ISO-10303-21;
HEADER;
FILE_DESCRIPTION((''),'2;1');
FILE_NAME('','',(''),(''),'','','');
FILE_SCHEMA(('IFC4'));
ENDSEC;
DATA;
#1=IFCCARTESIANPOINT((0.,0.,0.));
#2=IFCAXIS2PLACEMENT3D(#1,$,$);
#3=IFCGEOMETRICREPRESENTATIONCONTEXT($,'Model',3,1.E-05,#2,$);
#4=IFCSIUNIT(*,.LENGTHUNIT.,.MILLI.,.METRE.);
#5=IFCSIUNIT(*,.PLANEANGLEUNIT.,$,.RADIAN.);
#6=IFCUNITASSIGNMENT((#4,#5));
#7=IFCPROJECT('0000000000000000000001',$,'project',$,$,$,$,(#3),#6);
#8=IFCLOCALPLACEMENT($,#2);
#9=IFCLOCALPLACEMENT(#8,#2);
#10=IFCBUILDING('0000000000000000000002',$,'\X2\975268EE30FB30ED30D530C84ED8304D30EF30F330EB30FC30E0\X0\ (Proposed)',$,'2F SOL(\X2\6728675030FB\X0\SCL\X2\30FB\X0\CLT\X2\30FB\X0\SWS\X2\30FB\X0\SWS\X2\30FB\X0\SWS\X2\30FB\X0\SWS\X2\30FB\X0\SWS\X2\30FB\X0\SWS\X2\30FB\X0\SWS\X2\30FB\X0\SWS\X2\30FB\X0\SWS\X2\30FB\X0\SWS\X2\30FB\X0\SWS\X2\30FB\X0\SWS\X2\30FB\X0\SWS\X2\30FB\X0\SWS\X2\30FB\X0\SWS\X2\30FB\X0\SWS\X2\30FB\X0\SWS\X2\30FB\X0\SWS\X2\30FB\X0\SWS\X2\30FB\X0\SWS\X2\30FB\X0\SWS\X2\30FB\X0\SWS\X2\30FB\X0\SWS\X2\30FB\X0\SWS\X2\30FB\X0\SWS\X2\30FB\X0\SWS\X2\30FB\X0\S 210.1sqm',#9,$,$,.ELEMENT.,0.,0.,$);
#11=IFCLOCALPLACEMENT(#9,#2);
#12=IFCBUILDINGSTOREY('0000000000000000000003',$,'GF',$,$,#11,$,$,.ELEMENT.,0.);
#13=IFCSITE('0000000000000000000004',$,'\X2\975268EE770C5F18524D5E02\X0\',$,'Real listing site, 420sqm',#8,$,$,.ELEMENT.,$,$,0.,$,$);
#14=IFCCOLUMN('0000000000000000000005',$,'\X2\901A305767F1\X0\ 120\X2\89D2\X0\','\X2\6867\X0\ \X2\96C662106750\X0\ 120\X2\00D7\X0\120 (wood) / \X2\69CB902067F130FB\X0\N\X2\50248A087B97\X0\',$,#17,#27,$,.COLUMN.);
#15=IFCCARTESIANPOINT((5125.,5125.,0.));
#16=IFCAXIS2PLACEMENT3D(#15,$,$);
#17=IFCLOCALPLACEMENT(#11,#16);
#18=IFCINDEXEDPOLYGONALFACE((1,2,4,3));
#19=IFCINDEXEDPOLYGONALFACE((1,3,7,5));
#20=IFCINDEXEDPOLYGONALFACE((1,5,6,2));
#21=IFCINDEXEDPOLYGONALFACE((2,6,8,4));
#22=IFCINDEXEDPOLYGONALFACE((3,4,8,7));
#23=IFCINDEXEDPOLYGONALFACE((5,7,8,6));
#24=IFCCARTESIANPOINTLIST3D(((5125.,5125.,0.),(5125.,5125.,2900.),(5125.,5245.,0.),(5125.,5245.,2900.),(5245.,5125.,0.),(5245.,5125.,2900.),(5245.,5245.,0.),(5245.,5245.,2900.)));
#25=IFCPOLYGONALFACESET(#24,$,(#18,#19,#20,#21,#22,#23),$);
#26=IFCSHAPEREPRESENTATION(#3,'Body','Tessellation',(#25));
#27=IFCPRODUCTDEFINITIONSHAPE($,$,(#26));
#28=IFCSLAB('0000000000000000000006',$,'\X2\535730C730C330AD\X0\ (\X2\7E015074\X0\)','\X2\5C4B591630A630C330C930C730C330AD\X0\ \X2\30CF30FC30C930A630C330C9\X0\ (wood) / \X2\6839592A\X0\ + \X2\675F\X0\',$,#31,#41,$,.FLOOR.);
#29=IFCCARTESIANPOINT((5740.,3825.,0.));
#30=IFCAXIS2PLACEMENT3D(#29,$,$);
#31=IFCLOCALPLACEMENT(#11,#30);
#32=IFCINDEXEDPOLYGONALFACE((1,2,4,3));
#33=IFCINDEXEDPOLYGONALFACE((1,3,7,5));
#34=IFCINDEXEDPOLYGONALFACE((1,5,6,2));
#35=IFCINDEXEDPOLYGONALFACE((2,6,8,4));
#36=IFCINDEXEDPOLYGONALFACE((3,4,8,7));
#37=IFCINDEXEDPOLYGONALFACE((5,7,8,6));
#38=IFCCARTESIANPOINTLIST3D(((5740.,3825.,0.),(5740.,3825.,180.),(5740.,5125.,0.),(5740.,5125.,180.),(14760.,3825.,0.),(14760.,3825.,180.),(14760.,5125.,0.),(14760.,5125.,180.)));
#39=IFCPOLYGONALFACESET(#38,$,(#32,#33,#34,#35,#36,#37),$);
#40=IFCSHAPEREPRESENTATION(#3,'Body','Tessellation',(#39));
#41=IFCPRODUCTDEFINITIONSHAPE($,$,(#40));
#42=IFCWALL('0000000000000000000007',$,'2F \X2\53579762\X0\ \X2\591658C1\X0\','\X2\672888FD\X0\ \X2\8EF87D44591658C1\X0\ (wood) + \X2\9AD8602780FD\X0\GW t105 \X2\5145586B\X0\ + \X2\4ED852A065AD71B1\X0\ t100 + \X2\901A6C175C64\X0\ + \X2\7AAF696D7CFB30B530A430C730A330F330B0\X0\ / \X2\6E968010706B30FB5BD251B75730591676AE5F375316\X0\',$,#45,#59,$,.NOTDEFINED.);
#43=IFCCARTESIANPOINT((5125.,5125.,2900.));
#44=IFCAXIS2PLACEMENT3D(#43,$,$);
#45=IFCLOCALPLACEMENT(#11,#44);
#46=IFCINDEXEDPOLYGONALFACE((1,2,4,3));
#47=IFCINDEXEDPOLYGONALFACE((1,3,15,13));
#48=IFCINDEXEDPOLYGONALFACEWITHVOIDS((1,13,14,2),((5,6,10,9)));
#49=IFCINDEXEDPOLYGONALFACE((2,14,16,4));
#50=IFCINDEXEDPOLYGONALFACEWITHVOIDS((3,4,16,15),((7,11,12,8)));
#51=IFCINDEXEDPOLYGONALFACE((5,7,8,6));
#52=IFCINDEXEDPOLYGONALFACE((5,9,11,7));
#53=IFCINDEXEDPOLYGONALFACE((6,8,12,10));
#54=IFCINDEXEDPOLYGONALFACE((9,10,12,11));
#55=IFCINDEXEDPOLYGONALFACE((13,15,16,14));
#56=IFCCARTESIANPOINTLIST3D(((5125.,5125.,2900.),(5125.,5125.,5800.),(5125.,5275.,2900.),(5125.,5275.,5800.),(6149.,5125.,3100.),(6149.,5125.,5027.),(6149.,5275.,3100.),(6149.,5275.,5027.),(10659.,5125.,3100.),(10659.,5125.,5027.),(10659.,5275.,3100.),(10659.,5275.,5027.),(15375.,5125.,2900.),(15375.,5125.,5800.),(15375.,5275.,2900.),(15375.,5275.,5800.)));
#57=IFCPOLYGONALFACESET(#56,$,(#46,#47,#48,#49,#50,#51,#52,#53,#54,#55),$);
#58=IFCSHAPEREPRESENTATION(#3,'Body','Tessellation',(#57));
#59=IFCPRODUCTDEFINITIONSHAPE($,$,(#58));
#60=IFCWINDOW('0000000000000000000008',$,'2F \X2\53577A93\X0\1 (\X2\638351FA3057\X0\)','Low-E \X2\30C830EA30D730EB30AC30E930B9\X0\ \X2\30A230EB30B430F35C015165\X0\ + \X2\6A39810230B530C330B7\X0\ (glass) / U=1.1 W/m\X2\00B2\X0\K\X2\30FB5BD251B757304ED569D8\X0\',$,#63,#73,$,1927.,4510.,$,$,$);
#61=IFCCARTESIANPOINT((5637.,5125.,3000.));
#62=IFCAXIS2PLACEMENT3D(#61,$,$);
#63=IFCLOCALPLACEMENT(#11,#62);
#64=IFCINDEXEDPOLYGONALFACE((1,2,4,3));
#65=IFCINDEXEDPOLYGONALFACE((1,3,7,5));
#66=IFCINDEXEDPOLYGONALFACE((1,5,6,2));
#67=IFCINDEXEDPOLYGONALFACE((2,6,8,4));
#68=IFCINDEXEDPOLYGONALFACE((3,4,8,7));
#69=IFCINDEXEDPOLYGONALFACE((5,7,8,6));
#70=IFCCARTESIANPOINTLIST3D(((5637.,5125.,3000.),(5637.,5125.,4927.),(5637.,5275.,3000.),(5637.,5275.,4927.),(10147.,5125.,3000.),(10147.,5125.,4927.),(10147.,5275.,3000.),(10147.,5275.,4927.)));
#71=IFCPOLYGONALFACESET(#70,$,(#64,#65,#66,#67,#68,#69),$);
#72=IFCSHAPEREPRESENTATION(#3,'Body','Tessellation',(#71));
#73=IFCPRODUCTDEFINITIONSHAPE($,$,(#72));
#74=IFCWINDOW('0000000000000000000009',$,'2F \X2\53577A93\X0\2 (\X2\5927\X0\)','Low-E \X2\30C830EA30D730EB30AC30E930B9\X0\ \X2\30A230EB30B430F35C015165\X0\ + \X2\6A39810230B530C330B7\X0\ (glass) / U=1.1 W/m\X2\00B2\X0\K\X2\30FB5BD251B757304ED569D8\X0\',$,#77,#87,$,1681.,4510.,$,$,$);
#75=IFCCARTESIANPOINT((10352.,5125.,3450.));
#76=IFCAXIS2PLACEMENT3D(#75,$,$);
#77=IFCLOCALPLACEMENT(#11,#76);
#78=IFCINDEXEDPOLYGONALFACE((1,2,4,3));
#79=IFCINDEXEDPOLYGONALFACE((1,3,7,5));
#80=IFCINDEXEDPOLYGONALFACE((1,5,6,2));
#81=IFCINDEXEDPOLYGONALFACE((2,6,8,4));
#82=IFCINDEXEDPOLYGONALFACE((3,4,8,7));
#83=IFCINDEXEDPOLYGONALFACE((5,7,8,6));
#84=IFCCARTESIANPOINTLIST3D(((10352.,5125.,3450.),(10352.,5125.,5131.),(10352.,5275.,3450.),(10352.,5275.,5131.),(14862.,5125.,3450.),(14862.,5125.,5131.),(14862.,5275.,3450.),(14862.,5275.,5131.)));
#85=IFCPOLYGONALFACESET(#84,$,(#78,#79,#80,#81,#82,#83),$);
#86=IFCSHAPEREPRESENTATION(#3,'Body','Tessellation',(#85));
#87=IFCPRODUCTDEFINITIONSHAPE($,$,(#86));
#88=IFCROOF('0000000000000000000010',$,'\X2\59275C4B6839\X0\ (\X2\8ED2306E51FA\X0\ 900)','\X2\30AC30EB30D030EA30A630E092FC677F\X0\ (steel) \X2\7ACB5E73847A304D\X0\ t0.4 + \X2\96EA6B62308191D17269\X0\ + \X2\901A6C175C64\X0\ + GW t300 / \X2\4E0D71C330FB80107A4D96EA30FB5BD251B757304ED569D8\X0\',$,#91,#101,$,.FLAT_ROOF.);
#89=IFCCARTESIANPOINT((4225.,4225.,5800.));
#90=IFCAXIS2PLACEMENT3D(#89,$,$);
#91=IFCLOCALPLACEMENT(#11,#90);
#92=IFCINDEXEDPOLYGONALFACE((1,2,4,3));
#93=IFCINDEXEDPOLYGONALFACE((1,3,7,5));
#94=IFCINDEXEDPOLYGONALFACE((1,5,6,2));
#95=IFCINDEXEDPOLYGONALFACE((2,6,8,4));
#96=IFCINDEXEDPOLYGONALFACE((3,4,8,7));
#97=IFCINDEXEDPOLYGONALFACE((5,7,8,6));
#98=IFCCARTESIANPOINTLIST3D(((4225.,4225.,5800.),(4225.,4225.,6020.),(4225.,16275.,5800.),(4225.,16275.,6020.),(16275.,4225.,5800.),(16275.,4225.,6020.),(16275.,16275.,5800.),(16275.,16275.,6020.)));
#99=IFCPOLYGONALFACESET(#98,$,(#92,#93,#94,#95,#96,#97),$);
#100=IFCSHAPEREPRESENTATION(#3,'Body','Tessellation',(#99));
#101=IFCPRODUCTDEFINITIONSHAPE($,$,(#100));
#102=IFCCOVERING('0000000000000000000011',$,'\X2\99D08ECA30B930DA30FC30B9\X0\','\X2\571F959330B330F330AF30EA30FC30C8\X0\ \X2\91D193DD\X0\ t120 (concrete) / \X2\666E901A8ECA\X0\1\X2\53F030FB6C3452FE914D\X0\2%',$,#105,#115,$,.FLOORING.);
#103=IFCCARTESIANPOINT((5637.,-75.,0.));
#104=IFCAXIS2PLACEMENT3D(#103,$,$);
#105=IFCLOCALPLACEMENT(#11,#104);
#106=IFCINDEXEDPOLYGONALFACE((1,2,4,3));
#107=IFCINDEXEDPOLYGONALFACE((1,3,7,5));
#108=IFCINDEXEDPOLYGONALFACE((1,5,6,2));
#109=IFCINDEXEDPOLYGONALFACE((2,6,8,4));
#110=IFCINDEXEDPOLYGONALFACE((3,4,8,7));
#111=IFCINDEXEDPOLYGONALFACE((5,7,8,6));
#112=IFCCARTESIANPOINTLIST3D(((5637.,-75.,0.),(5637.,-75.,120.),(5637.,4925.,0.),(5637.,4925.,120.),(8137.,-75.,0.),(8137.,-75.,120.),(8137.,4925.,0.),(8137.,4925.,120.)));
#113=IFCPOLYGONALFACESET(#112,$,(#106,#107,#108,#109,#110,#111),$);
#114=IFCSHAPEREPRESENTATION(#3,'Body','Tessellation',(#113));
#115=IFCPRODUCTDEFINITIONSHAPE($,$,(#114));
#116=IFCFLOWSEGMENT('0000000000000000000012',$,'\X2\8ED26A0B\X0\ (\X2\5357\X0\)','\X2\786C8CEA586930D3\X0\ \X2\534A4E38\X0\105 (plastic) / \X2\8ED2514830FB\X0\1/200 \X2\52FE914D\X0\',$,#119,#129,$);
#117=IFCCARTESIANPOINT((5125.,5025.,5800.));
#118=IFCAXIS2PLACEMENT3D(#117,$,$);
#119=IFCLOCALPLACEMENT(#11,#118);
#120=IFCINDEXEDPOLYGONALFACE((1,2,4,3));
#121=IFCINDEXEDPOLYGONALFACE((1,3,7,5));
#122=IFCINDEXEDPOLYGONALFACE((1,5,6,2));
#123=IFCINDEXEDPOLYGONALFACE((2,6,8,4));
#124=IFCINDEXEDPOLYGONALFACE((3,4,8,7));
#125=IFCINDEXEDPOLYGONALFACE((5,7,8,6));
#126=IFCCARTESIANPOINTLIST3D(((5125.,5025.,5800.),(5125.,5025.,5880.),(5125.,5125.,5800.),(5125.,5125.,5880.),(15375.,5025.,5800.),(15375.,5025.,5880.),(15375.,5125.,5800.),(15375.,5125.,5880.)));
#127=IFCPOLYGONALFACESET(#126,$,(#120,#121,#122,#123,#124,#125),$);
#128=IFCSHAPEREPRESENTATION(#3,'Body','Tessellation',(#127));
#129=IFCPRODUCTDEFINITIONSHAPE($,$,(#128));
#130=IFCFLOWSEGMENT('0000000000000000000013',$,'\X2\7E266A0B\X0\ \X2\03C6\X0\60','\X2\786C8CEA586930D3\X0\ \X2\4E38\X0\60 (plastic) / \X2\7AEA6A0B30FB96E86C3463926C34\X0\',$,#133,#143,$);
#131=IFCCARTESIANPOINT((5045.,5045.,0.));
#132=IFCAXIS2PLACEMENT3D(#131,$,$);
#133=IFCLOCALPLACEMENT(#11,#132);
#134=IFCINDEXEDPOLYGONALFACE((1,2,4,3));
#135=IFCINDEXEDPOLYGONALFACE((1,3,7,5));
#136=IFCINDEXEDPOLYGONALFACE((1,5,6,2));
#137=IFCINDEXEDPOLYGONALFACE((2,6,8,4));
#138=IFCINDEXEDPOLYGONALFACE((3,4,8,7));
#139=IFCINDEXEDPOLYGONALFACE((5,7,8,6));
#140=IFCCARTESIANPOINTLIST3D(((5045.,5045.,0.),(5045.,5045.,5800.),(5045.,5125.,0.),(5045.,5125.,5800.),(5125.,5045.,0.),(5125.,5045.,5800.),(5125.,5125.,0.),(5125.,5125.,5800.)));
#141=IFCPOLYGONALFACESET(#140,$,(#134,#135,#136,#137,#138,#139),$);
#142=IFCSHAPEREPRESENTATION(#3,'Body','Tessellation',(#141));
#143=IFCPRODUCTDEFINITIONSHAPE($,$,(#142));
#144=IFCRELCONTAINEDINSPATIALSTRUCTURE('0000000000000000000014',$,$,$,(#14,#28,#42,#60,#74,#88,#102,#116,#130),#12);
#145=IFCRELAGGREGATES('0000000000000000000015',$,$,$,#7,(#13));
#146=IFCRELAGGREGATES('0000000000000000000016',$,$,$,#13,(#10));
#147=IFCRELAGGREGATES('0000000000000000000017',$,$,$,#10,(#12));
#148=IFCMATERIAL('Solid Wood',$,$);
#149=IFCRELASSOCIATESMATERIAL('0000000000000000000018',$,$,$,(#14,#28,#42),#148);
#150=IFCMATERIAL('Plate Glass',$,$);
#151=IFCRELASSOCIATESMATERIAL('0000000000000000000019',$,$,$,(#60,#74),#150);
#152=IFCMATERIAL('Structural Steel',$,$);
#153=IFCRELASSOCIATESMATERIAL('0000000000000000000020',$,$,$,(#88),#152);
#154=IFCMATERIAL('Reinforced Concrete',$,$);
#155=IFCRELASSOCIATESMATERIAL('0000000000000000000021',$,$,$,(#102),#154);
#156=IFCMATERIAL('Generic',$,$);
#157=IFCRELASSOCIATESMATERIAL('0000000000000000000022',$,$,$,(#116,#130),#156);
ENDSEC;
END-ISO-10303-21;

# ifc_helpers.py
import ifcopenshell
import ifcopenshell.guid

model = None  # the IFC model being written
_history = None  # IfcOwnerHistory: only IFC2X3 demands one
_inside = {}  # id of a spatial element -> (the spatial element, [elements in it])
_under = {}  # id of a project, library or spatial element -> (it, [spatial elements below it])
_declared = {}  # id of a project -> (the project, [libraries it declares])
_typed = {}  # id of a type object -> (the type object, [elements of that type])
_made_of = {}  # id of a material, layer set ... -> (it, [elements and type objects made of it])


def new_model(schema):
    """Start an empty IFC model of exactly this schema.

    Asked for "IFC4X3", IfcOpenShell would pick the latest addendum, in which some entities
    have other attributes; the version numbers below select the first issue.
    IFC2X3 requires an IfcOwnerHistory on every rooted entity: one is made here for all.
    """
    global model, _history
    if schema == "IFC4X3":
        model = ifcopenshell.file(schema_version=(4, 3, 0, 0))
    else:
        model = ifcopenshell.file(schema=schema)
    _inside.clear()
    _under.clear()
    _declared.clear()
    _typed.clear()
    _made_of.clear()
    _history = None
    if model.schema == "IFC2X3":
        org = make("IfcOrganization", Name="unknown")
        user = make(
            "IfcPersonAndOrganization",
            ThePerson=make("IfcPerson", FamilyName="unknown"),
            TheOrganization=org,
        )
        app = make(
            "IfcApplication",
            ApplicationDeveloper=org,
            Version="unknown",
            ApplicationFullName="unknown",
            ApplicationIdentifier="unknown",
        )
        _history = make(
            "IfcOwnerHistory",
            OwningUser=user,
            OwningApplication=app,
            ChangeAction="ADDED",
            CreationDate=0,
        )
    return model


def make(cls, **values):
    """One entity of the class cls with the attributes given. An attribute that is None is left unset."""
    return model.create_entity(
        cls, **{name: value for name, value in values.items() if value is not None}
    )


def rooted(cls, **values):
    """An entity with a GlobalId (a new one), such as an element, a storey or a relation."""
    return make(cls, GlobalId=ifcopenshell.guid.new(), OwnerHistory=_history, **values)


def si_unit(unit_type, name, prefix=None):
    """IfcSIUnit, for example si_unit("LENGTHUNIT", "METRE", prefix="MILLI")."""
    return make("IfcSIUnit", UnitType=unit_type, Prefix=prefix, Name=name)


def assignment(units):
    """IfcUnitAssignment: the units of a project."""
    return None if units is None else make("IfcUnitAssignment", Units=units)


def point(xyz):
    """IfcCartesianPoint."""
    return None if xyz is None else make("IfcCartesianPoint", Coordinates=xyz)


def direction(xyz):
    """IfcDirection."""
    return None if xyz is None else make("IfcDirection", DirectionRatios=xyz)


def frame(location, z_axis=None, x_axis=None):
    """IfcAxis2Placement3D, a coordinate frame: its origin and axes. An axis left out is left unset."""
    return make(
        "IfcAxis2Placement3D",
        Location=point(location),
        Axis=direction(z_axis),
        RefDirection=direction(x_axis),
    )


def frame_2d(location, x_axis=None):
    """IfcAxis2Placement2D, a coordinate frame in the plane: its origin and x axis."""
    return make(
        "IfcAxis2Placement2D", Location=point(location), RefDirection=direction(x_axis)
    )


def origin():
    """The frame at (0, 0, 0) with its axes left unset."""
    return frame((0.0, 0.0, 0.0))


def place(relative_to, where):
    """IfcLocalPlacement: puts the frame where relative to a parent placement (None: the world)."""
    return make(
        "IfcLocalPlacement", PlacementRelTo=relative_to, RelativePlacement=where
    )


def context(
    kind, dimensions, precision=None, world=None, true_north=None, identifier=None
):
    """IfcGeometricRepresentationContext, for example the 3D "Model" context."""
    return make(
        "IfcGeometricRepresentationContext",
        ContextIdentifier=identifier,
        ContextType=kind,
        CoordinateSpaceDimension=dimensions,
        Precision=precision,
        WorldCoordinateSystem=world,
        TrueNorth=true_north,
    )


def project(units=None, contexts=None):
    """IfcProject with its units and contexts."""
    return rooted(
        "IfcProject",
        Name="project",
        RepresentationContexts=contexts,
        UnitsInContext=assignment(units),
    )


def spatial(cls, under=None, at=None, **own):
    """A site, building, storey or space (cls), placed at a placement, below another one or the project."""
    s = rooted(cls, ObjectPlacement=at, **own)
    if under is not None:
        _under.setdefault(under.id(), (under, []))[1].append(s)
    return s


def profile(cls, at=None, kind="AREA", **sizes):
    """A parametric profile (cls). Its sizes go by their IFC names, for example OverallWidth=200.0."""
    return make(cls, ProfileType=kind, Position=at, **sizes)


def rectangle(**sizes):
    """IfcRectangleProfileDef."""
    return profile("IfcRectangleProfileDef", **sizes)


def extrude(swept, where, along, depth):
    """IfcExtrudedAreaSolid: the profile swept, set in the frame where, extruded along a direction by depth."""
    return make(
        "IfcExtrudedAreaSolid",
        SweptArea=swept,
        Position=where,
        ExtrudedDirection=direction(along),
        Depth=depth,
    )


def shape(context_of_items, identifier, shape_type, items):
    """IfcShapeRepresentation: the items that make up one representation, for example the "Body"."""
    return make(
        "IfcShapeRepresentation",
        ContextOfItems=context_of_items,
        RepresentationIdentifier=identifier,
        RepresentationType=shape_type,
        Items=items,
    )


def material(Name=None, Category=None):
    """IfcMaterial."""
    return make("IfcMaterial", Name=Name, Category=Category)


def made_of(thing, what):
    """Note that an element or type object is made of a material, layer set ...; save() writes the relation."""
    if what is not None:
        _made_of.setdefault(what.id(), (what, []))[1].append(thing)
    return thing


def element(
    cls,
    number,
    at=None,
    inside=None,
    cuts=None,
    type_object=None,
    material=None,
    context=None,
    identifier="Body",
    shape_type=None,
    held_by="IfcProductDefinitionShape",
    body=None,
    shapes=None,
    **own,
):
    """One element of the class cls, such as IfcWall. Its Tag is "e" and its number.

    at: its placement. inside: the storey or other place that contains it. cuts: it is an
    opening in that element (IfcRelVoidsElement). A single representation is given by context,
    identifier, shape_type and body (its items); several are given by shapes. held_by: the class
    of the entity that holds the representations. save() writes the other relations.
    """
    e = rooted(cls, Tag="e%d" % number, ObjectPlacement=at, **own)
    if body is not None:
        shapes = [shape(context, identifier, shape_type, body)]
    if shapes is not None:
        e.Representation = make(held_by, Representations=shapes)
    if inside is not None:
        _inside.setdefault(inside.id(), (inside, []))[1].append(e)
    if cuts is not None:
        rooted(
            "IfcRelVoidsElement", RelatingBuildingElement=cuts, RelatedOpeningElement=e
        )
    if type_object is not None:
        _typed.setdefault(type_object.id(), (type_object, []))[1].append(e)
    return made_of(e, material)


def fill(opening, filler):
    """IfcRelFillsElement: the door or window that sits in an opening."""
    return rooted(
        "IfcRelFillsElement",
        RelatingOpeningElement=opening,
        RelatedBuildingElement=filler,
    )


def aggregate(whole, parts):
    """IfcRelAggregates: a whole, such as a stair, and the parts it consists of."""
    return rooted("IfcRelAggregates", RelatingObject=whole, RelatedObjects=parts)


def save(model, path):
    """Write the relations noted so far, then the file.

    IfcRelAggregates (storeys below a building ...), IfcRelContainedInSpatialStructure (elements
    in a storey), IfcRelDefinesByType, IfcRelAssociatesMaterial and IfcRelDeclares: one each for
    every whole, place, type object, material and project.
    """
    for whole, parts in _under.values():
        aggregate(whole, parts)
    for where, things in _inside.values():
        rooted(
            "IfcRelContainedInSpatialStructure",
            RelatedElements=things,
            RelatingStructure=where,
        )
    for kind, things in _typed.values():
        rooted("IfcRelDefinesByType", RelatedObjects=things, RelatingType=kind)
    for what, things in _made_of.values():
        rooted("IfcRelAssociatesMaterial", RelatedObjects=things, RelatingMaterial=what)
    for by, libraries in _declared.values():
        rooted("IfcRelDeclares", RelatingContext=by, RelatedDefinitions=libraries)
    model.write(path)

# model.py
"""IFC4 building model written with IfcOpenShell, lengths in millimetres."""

from ifc_helpers import new_model, si_unit, frame, frame_2d, origin, place, context, project, spatial, rectangle, extrude, material, element, fill, save


model = new_model("IFC4")

# Units and contexts
model_context = context("Model", 3, precision=1e-05, world=origin())
ifc_project = project(units=[si_unit("LENGTHUNIT", "METRE", prefix="MILLI"), si_unit("PLANEANGLEUNIT", "RADIAN")], contexts=[model_context])

# Site, building, storey
site_placement = place(None, origin())
site = spatial("IfcSite", under=ifc_project, at=site_placement, Name="青森県弘前市", ObjectType="Real listing site, 420sqm", CompositionType="ELEMENT", RefElevation=0.0)
building_placement = place(site_placement, origin())
building = spatial("IfcBuilding", under=site, at=building_placement, Name="青森・ロフト付きワンルーム (Proposed)", ObjectType="2F SOL(木材・SCL・CLT・SWS・SWS・SWS・SWS・SWS・SWS・SWS・SWS・SWS・SWS・SWS・SWS・SWS・SWS・SWS・SWS・SWS・SWS・SWS・SWS・SWS・SWS・SWS・SWS・SWS・SWS・S 210.1sqm", CompositionType="ELEMENT", ElevationOfRefHeight=0.0, ElevationOfTerrain=0.0)
storey_placement = place(building_placement, origin())
storey = spatial("IfcBuildingStorey", under=building, at=storey_placement, Name="GF", CompositionType="ELEMENT", Elevation=0.0)

# Column
ifc_material_1 = material(Name="Solid Wood")
column_placement = place(storey_placement, frame((5125.0, 5125.0, 0.0)))
element("IfcColumn", 1, at=column_placement, inside=storey, material=ifc_material_1, Name="通し柱 120角", Description="桧 集成材 120×120 (wood) / 構造柱・N値計算", PredefinedType="COLUMN", context=model_context, shape_type="SweptSolid", body=[
    extrude(rectangle(XDim=120.0, YDim=120.0, at=frame_2d((60.0, 60.0))), frame((5125.0, 5125.0, 0.0)), (0.0, 0.0, 1.0), 2900.0),
])

# Slab
ifc_material_2 = material(Name="Reinforced Concrete")
slab_1_placement = place(storey_placement, frame((5740.0, 3825.0, 0.0)))
element("IfcSlab", 2, at=slab_1_placement, inside=storey, material=ifc_material_1, Name="南デッキ (縁側)", Description="屋外ウッドデッキ ハードウッド (wood) / 根太 + 束", PredefinedType="FLOOR", context=model_context, shape_type="SweptSolid", body=[
    extrude(rectangle(XDim=9020.0, YDim=1300.0, at=frame_2d((4510.0, 650.0))), frame((5740.0, 3825.0, 0.0)), (0.0, 0.0, 1.0), 180.0),
])

# Shared definitions
ifc_material_3 = material(Name="Plate Glass")

# Wall, openings, windows
wall_1_placement = place(storey_placement, frame((5125.0, 5125.0, 2900.0)))
wall_1 = element("IfcWall", 3, at=wall_1_placement, inside=storey, material=ifc_material_1, Name="2F 南面 外壁", Description="木製 軸組外壁 (wood) + 高性能GW t105 充填 + 付加断熱 t100 + 通気層 + 窯業系サイディング / 準耐火・寒冷地外皮強化", PredefinedType="NOTDEFINED", context=model_context, shape_type="SweptSolid", body=[
    extrude(rectangle(XDim=10250.0, YDim=150.0, at=frame_2d((5125.0, 75.0))), frame((5125.0, 5125.0, 2900.0)), (0.0, 0.0, 1.0), 2900.0),
])
opening_1_placement = place(storey_placement, frame((5637.0, 5125.0, 3000.0)))
opening_1 = element("IfcOpeningElement", 4, at=opening_1_placement, cuts=wall_1, PredefinedType="NOTDEFINED", context=model_context, shape_type="SweptSolid", body=[
    extrude(rectangle(XDim=4510.0, YDim=150.0, at=frame_2d((2255.0, 75.0))), frame((5637.0, 5125.0, 3000.0)), (0.0, 0.0, 1.0), 1927.0),
])
opening_2_placement = place(storey_placement, frame((10352.0, 5125.0, 3450.0)))
opening_2 = element("IfcOpeningElement", 5, at=opening_2_placement, cuts=wall_1, PredefinedType="NOTDEFINED", context=model_context, shape_type="SweptSolid", body=[
    extrude(rectangle(XDim=4510.0, YDim=150.0, at=frame_2d((2255.0, 75.0))), frame((10352.0, 5125.0, 3450.0)), (0.0, 0.0, 1.0), 1681.0),
])
window_1_placement = place(storey_placement, frame((5637.0, 5125.0, 3000.0)))
window_1 = element("IfcWindow", 6, at=window_1_placement, inside=storey, material=ifc_material_3, Name="2F 南窓1 (掃出し)", Description="Low-E トリプルガラス アルゴン封入 + 樹脂サッシ (glass) / U=1.1 W/m²K・寒冷地仕様", OverallHeight=1927.0, OverallWidth=4510.0, context=model_context, shape_type="SweptSolid", body=[
    extrude(rectangle(XDim=4510.0, YDim=150.0, at=frame_2d((2255.0, 75.0))), frame((5637.0, 5125.0, 3000.0)), (0.0, 0.0, 1.0), 1927.0),
])
fill(opening_1, window_1)
window_2_placement = place(storey_placement, frame((10352.0, 5125.0, 3450.0)))
window_2 = element("IfcWindow", 7, at=window_2_placement, inside=storey, material=ifc_material_3, Name="2F 南窓2 (大)", Description="Low-E トリプルガラス アルゴン封入 + 樹脂サッシ (glass) / U=1.1 W/m²K・寒冷地仕様", OverallHeight=1681.0, OverallWidth=4510.0, context=model_context, shape_type="SweptSolid", body=[
    extrude(rectangle(XDim=4510.0, YDim=150.0, at=frame_2d((2255.0, 75.0))), frame((10352.0, 5125.0, 3450.0)), (0.0, 0.0, 1.0), 1681.0),
])
fill(opening_2, window_2)

# Roof
ifc_material_4 = material(Name="Structural Steel")
roof_placement = place(storey_placement, frame((4225.0, 4225.0, 5800.0)))
element("IfcRoof", 8, at=roof_placement, inside=storey, material=ifc_material_4, Name="大屋根 (軒の出 900)", Description="ガルバリウム鋼板 (steel) 立平葺き t0.4 + 雪止め金物 + 通気層 + GW t300 / 不燃・耐積雪・寒冷地仕様", PredefinedType="FLAT_ROOF", context=model_context, shape_type="SweptSolid", body=[
    extrude(rectangle(XDim=12050.0, YDim=12050.0, at=frame_2d((6025.0, 6025.0))), frame((4225.0, 4225.0, 5800.0)), (0.0, 0.0, 1.0), 220.0),
])

# Covering
covering_placement = place(storey_placement, frame((5637.0, -75.0, 0.0)))
element("IfcCovering", 9, at=covering_placement, inside=storey, material=ifc_material_2, Name="駐車スペース", Description="土間コンクリート 金鏝 t120 (concrete) / 普通車1台・水勾配2%", PredefinedType="FLOORING", context=model_context, shape_type="SweptSolid", body=[
    extrude(rectangle(XDim=2500.0, YDim=5000.0, at=frame_2d((1250.0, 2500.0))), frame((5637.0, -75.0, 0.0)), (0.0, 0.0, 1.0), 120.0),
])

# Flow segments
ifc_material_5 = material(Name="Generic")
flow_segment_1_placement = place(storey_placement, frame((5125.0, 5025.0, 5800.0)))
element("IfcFlowSegment", 10, at=flow_segment_1_placement, inside=storey, material=ifc_material_5, Name="軒樋 (南)", Description="硬質塩ビ 半丸105 (plastic) / 軒先・1/200 勾配", context=model_context, shape_type="SweptSolid", body=[
    extrude(rectangle(XDim=10250.0, YDim=100.0, at=frame_2d((5125.0, 50.0))), frame((5125.0, 5025.0, 5800.0)), (0.0, 0.0, 1.0), 80.0),
])
flow_segment_2_placement = place(storey_placement, frame((5045.0, 5045.0, 0.0)))
element("IfcFlowSegment", 11, at=flow_segment_2_placement, inside=storey, material=ifc_material_5, Name="縦樋 φ60", Description="硬質塩ビ 丸60 (plastic) / 竪樋・雨水排水", context=model_context, shape_type="SweptSolid", body=[
    extrude(rectangle(XDim=80.0, YDim=80.0, at=frame_2d((40.0, 40.0))), frame((5045.0, 5045.0, 0.0)), (0.0, 0.0, 1.0), 5800.0),
])

save(model, "model.ifc")
